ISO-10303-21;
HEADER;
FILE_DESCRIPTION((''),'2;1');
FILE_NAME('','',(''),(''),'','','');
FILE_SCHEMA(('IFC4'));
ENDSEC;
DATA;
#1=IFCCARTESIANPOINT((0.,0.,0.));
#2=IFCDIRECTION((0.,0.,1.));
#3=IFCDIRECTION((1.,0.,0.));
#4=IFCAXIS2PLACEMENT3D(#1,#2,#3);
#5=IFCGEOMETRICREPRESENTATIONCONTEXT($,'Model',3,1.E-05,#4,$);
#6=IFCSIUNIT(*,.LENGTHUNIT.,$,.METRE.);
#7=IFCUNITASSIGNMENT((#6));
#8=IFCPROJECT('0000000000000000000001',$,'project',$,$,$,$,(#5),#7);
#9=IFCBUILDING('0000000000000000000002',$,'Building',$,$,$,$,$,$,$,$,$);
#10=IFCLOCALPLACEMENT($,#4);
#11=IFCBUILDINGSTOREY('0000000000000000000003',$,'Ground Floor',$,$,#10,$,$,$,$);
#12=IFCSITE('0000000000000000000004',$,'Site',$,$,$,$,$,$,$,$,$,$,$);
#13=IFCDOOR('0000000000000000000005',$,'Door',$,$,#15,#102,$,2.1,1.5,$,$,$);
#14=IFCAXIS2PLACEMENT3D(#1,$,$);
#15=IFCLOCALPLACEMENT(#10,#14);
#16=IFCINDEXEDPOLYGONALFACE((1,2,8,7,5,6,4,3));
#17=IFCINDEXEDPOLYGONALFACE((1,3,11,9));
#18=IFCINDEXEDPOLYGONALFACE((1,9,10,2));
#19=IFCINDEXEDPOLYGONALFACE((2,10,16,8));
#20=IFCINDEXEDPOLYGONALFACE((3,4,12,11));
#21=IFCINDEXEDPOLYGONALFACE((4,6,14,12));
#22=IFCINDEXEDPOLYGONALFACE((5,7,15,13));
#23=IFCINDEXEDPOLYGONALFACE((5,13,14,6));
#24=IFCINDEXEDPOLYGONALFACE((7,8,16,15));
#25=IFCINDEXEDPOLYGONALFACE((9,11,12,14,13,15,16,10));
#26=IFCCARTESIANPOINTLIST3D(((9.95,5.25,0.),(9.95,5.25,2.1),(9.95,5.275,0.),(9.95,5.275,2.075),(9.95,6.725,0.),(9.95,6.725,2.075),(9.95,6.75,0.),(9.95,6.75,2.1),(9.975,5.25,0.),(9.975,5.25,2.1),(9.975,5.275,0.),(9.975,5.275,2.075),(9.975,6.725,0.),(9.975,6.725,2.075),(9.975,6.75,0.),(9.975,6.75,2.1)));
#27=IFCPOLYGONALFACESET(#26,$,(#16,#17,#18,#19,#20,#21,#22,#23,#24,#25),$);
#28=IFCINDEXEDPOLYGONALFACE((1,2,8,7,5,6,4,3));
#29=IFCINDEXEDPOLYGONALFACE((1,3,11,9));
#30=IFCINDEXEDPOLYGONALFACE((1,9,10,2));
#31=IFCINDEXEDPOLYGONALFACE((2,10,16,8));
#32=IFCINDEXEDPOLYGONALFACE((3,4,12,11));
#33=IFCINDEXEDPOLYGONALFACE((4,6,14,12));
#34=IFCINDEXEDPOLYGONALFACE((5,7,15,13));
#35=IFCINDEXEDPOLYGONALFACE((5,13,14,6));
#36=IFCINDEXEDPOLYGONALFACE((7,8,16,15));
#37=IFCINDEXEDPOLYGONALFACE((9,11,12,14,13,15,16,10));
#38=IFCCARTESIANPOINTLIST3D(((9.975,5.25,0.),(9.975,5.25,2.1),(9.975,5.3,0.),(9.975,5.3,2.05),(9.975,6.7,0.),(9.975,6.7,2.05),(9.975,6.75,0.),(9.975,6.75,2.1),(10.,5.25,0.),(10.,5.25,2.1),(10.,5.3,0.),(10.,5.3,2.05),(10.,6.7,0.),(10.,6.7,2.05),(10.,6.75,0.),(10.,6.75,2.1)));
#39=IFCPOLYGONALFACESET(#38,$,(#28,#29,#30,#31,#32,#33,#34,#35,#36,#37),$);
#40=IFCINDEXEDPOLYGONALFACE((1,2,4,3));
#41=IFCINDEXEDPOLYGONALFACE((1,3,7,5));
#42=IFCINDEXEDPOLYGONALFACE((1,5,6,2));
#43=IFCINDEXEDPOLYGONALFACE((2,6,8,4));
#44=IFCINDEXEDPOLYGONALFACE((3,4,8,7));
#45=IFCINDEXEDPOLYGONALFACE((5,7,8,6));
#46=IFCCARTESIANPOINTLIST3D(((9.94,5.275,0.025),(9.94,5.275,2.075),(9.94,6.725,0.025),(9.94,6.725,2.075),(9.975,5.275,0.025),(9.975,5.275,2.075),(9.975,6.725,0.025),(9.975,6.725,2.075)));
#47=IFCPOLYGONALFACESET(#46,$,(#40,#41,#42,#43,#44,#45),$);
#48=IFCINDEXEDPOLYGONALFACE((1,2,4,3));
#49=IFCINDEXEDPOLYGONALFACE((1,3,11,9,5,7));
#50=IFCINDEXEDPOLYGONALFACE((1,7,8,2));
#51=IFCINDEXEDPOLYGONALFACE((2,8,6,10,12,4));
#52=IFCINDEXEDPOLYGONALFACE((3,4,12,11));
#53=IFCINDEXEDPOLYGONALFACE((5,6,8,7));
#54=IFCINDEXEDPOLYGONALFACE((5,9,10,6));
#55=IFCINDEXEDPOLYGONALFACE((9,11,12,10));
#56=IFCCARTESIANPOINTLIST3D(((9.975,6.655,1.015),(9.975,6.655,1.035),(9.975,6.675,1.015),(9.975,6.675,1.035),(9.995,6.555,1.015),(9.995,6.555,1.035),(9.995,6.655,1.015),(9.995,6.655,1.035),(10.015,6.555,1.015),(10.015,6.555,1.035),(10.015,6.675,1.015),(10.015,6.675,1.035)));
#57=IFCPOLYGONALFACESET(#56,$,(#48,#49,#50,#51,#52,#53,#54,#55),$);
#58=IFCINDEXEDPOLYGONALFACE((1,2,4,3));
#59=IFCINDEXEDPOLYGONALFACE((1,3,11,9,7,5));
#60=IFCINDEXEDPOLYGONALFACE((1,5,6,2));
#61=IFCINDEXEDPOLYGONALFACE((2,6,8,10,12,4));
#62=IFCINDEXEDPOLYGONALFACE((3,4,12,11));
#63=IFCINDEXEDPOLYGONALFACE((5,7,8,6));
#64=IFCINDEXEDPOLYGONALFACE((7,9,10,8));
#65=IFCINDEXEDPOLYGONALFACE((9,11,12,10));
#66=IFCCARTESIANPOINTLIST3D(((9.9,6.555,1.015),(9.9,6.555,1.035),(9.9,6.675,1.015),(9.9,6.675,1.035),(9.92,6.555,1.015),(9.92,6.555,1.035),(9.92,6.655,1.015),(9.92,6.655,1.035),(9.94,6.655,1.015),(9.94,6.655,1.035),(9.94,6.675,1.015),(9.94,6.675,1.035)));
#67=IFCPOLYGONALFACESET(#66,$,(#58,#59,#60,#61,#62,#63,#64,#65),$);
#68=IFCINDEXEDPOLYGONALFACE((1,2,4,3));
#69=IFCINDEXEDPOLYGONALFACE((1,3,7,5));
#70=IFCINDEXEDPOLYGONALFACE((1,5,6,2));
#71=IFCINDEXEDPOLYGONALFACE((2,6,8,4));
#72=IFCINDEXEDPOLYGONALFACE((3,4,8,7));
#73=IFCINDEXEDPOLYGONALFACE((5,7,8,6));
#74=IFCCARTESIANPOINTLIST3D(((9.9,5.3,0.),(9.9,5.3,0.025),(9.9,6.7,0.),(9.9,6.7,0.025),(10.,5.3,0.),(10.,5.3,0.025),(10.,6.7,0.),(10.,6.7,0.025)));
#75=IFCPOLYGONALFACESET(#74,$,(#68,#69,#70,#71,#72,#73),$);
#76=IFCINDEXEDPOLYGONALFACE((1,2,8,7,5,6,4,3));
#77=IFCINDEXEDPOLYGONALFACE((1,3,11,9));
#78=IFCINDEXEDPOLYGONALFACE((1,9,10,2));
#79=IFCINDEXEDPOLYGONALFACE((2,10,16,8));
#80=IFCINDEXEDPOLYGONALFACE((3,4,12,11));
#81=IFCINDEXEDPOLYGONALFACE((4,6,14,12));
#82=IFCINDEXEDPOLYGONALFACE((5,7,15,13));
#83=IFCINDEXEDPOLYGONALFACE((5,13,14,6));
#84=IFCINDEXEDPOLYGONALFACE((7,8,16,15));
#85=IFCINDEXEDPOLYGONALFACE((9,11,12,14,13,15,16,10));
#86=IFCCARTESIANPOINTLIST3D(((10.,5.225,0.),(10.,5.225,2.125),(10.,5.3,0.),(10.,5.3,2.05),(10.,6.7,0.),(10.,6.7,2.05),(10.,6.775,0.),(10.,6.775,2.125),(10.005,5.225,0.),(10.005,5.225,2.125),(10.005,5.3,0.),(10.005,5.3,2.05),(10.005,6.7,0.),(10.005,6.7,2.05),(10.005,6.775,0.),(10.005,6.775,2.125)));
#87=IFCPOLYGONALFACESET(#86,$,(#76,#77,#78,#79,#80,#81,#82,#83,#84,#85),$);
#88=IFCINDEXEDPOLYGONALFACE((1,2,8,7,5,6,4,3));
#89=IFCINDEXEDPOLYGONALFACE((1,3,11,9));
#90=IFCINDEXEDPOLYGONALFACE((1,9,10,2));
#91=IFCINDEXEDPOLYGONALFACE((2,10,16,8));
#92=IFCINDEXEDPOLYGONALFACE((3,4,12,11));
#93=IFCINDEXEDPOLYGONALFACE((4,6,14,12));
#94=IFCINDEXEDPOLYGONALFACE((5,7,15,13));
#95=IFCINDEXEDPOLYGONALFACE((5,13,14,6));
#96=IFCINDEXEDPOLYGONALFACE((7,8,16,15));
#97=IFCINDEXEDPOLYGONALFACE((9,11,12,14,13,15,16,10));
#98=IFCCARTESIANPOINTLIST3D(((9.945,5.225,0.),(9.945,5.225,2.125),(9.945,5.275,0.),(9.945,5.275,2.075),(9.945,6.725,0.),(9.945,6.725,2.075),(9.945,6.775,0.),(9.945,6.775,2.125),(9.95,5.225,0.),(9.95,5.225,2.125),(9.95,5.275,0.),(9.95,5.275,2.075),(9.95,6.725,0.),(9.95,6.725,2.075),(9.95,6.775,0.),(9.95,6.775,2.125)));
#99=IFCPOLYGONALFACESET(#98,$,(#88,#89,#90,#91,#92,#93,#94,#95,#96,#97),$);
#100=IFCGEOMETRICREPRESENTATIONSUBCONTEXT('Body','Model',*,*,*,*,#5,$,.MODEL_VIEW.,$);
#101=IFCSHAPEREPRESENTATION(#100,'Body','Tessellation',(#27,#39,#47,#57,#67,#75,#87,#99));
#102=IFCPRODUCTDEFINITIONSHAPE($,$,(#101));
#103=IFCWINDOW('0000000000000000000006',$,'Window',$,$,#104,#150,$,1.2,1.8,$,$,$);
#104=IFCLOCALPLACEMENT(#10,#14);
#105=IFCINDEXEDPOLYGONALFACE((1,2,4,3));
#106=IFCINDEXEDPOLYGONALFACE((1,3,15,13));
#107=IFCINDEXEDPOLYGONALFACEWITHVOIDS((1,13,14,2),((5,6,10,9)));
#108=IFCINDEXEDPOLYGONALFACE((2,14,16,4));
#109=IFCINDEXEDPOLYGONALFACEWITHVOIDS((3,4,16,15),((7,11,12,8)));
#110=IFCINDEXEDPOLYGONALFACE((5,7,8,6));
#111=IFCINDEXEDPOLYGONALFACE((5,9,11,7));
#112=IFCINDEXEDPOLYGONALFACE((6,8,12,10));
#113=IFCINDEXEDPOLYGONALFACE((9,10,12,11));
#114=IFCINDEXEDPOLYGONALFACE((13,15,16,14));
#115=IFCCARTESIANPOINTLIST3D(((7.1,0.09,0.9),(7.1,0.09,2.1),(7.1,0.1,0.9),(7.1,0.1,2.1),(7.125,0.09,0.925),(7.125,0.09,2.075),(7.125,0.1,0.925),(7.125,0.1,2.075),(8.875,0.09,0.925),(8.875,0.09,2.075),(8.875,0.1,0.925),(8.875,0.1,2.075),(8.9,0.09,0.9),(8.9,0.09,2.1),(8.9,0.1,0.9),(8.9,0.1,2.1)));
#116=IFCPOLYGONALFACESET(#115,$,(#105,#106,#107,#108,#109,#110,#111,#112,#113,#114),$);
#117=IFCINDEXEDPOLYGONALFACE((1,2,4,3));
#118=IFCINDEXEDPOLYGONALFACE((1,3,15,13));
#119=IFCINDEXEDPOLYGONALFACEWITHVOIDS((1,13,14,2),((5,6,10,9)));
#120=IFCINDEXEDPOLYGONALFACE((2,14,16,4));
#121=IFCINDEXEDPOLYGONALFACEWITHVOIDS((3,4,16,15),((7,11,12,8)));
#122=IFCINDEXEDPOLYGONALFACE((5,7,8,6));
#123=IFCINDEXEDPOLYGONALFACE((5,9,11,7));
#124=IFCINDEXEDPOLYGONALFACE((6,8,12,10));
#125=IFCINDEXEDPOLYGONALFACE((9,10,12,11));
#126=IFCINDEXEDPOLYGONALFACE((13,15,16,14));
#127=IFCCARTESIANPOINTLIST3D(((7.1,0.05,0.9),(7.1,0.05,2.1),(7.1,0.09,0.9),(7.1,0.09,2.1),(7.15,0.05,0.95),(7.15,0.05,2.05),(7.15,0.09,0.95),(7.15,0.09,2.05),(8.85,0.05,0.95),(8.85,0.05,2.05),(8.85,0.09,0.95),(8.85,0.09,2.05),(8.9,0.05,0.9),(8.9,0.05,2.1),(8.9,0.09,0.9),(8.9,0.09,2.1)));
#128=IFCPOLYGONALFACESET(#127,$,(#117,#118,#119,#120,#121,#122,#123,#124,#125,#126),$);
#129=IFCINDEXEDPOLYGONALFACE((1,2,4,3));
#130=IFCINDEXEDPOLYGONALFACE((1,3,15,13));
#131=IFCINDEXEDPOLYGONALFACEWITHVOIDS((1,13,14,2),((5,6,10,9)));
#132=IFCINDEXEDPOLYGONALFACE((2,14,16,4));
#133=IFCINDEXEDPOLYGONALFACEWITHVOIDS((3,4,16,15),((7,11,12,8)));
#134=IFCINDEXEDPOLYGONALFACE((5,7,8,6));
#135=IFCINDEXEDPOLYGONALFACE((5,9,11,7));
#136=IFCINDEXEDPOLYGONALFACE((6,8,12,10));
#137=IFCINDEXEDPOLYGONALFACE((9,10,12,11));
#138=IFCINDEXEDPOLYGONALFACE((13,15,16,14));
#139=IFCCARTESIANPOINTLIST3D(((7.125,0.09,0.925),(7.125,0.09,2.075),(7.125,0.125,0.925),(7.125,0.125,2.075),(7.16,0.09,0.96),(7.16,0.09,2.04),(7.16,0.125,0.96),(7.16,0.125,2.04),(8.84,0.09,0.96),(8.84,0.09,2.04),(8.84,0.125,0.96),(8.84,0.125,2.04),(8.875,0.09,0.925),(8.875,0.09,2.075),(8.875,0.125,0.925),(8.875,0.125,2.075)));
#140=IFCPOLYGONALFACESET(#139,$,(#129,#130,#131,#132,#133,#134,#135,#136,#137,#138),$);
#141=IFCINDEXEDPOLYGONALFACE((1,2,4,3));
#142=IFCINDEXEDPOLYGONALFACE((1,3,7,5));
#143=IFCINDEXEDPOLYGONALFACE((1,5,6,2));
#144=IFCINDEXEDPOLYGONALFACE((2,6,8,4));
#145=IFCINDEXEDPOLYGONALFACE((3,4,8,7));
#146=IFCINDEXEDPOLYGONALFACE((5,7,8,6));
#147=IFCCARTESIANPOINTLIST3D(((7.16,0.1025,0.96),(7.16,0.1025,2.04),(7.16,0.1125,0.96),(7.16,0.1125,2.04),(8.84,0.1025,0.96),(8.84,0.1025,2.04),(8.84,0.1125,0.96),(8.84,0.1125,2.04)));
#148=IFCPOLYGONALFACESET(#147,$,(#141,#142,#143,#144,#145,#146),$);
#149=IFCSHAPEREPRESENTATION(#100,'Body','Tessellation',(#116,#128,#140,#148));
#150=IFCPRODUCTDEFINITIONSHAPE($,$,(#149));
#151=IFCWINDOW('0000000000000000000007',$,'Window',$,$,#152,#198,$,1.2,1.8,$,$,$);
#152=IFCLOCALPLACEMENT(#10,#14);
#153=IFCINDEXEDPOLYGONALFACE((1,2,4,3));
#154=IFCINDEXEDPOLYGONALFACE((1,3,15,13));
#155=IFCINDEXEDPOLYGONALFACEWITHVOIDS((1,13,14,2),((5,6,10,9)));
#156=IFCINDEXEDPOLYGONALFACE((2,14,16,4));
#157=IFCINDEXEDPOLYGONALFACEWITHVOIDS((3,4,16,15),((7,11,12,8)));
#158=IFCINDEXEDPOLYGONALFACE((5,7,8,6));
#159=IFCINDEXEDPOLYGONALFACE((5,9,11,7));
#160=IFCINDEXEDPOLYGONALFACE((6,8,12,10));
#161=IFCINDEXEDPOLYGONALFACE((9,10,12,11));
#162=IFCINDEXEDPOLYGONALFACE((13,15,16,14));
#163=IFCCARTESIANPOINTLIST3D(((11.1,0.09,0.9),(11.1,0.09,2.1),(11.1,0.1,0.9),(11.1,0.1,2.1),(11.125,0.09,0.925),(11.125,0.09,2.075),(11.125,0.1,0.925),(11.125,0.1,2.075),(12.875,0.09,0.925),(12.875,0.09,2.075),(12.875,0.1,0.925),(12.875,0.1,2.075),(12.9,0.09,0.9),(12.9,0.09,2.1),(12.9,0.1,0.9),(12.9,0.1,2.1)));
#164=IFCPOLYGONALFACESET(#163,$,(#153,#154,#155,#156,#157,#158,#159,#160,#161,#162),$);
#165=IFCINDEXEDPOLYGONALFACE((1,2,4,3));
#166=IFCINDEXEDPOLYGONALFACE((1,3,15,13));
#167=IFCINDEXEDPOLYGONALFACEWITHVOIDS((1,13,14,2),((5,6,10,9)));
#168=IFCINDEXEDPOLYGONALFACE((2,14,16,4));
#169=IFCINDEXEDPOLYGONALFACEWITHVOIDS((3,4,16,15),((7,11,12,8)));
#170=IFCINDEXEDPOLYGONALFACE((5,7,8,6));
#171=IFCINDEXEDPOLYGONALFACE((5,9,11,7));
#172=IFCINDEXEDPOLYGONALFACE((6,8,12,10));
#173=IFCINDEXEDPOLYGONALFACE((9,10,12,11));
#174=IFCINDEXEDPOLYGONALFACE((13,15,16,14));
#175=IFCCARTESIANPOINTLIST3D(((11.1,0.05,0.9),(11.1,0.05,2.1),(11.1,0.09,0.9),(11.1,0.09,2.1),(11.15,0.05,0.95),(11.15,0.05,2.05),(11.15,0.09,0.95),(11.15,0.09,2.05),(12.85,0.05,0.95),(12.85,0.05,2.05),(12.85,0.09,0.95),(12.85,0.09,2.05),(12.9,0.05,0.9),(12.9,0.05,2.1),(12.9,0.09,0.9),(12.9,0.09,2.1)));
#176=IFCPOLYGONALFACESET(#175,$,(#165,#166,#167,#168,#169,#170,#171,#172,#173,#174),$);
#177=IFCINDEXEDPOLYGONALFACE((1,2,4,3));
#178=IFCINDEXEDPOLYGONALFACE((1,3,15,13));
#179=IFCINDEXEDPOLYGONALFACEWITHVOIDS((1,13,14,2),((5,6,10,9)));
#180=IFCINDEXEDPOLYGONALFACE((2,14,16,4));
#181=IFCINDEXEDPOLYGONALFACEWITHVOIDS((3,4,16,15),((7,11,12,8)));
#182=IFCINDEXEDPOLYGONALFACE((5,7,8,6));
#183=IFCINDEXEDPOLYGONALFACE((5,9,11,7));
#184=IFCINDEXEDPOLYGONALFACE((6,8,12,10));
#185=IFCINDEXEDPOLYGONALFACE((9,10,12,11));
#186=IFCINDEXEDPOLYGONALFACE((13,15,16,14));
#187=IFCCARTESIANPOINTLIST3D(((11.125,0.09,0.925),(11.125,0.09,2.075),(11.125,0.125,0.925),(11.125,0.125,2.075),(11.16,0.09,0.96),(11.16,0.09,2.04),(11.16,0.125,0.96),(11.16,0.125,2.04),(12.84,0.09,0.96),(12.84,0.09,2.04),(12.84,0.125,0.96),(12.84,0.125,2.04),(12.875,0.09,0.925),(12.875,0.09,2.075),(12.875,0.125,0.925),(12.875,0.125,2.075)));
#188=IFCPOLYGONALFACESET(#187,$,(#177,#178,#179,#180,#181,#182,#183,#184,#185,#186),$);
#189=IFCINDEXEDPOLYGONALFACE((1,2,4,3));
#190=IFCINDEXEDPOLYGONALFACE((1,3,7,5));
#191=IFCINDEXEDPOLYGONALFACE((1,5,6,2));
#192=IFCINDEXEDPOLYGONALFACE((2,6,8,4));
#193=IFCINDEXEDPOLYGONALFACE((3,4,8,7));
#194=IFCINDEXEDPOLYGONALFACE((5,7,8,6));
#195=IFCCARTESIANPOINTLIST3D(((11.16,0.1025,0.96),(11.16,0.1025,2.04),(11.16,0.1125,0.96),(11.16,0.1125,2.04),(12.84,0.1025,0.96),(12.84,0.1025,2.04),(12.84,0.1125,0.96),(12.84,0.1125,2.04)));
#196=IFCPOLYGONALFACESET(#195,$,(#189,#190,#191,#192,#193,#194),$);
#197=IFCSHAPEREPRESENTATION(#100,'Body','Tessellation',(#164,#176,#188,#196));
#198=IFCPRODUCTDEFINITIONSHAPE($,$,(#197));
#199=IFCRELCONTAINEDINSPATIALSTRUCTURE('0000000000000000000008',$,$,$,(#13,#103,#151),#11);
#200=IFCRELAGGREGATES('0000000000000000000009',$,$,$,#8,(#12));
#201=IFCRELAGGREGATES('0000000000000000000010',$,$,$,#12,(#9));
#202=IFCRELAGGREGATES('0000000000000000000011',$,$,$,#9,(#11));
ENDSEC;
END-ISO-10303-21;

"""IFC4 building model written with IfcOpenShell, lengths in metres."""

from ifc_helpers import new_model, si_unit, frame, origin_with_axes, place, context, subcontext, project, spatial, line, indexed_curve, outline, extrude, element, save


model = new_model("IFC4")

# Units and contexts
model_context = context("Model", 3, precision=1e-05, world=origin_with_axes())
body_context = subcontext(model_context, "Body", "Model", "MODEL_VIEW")
ifc_project = project(units=[si_unit("LENGTHUNIT", "METRE")], contexts=[model_context])

# Site, building, storey
site = spatial("IfcSite", under=ifc_project, Name="Site")
building = spatial("IfcBuilding", under=site, Name="Building")
storey_placement = place(None, origin_with_axes())
storey = spatial("IfcBuildingStorey", under=building, at=storey_placement, Name="Ground Floor")

# Door
door_1_placement = place(storey_placement, frame((10.0, 5.25, 0.0), z_axis=(0.0, 0.0, 1.0), x_axis=(0.0, 1.0, 0.0)))
element("IfcDoor", 1, at=door_1_placement, inside=storey, Name="Door", OverallHeight=2.1, OverallWidth=1.5, context=body_context, shape_type="SweptSolid", body=[
    extrude(outline(indexed_curve([(0.0, 0.0), (0.0, 2.1), (1.5, 2.1), (1.5, 0.0), (1.475, 0.0), (1.475, 2.075), (0.025, 2.075), (0.025, 0.0)], segments=[line(1, 2, 3, 4, 5, 6, 7, 8, 1)])), frame((0.0, 0.025, 0.0), z_axis=(0.0, -1.0, 0.0), x_axis=(1.0, 0.0, 0.0)), (0.0, 0.0, -1.0), 0.025),
    extrude(outline(indexed_curve([(0.0, 0.0), (0.0, 2.1), (1.5, 2.1), (1.5, 0.0), (1.45, 0.0), (1.45, 2.05), (0.05, 2.05), (0.05, 0.0)], segments=[line(1, 2, 3, 4, 5, 6, 7, 8, 1)])), frame((0.0, 0.0, 0.0), z_axis=(0.0, -1.0, 0.0), x_axis=(1.0, 0.0, 0.0)), (0.0, 0.0, -1.0), 0.025),
    extrude(outline(indexed_curve([(0.0, 0.0), (1.45, 0.0), (1.45, 0.035), (0.0, 0.035)], segments=[line(1, 2, 3, 4, 1)])), frame((0.025, 0.025, 0.025), z_axis=(0.0, 0.0, 1.0), x_axis=(1.0, 0.0, 0.0)), (0.0, 0.0, 1.0), 2.05),
    extrude(outline(indexed_curve([(0.0, 0.0), (0.0, -0.04), (-0.12, -0.04), (-0.12, -0.02), (-0.02, -0.02), (-0.02, 0.0)], segments=[line(1, 2, 3, 4, 5, 6, 1)])), frame((1.425, 0.025, 1.015), z_axis=(0.0, 0.0, 1.0), x_axis=(1.0, 0.0, 0.0)), (0.0, 0.0, 1.0), 0.02),
    extrude(outline(indexed_curve([(0.0, 0.0), (0.0, 0.04), (-0.12, 0.04), (-0.12, 0.02), (-0.02, 0.02), (-0.02, 0.0)], segments=[line(1, 2, 3, 4, 5, 6, 1)])), frame((1.425, 0.06, 1.015), z_axis=(0.0, 0.0, 1.0), x_axis=(1.0, 0.0, 0.0)), (0.0, 0.0, 1.0), 0.02),
    extrude(outline(indexed_curve([(0.0, 0.0), (1.4, 0.0), (1.4, 0.1), (0.0, 0.1)], segments=[line(1, 2, 3, 4, 1)])), frame((0.05, 0.0, 0.0), z_axis=(0.0, 0.0, 1.0), x_axis=(1.0, 0.0, 0.0)), (0.0, 0.0, 1.0), 0.025),
    extrude(outline(indexed_curve([(0.0, 0.0), (0.0, 2.125), (1.55, 2.125), (1.55, 0.0), (1.475, 0.0), (1.475, 2.05), (0.075, 2.05), (0.075, 0.0)], segments=[line(1, 2, 3, 4, 5, 6, 7, 8, 1)])), frame((-0.025, -0.005, 0.0), z_axis=(0.0, -1.0, 0.0), x_axis=(1.0, 0.0, 0.0)), (0.0, 0.0, -1.0), 0.005),
    extrude(outline(indexed_curve([(0.0, 0.0), (0.0, 2.125), (1.55, 2.125), (1.55, 0.0), (1.5, 0.0), (1.5, 2.075), (0.05, 2.075), (0.05, 0.0)], segments=[line(1, 2, 3, 4, 5, 6, 7, 8, 1)])), frame((-0.025, 0.05, 0.0), z_axis=(0.0, -1.0, 0.0), x_axis=(1.0, 0.0, 0.0)), (0.0, 0.0, -1.0), 0.005),
])

# Windows
for number, where, z_axis, x_axis, name in (
    (2, (7.1, 0.0, 0.9), (0.0, 0.0, 1.0), (1.0, 0.0, 0.0), "Window"),
    (3, (11.1, 0.0, 0.9), (0.0, 0.0, 1.0), (1.0, 0.0, 0.0), "Window"),
):
    element("IfcWindow", number, at=place(storey_placement, frame(where, z_axis=z_axis, x_axis=x_axis)), inside=storey, Name=name, OverallHeight=1.2, OverallWidth=1.8, context=body_context, shape_type="SweptSolid", body=[
        extrude(outline(indexed_curve([(0.0, 0.0), (1.8, 0.0), (1.8, 1.2), (0.0, 1.2)], segments=[line(1, 2, 3, 4, 1)]), holes=[indexed_curve([(0.025, 0.025), (1.775, 0.025), (1.775, 1.175), (0.025, 1.175)], segments=[line(1, 2, 3, 4, 1)])]), frame((0.0, 0.09, 0.0), z_axis=(0.0, -1.0, 0.0), x_axis=(1.0, 0.0, 0.0)), (0.0, 0.0, -1.0), 0.01),
        extrude(outline(indexed_curve([(0.0, 0.0), (1.8, 0.0), (1.8, 1.2), (0.0, 1.2)], segments=[line(1, 2, 3, 4, 1)]), holes=[indexed_curve([(0.05, 0.05), (1.75, 0.05), (1.75, 1.15), (0.05, 1.15)], segments=[line(1, 2, 3, 4, 1)])]), frame((0.0, 0.05, 0.0), z_axis=(0.0, -1.0, 0.0), x_axis=(1.0, 0.0, 0.0)), (0.0, 0.0, -1.0), 0.04),
        extrude(outline(indexed_curve([(0.0, 0.0), (1.75, 0.0), (1.75, 1.15), (0.0, 1.15)], segments=[line(1, 2, 3, 4, 1)]), holes=[indexed_curve([(0.035, 0.035), (1.715, 0.035), (1.715, 1.115), (0.035, 1.115)], segments=[line(1, 2, 3, 4, 1)])]), frame((0.025, 0.09, 0.025), z_axis=(0.0, -1.0, 0.0), x_axis=(1.0, 0.0, 0.0)), (0.0, 0.0, -1.0), 0.035),
        extrude(outline(indexed_curve([(0.035, 0.035), (1.715, 0.035), (1.715, 1.115), (0.035, 1.115)], segments=[line(1, 2, 3, 4, 1)])), frame((0.025, 0.1025, 0.025), z_axis=(0.0, -1.0, 0.0), x_axis=(1.0, 0.0, 0.0)), (0.0, 0.0, -1.0), 0.01),
    ])

save(model, "model.ifc")
